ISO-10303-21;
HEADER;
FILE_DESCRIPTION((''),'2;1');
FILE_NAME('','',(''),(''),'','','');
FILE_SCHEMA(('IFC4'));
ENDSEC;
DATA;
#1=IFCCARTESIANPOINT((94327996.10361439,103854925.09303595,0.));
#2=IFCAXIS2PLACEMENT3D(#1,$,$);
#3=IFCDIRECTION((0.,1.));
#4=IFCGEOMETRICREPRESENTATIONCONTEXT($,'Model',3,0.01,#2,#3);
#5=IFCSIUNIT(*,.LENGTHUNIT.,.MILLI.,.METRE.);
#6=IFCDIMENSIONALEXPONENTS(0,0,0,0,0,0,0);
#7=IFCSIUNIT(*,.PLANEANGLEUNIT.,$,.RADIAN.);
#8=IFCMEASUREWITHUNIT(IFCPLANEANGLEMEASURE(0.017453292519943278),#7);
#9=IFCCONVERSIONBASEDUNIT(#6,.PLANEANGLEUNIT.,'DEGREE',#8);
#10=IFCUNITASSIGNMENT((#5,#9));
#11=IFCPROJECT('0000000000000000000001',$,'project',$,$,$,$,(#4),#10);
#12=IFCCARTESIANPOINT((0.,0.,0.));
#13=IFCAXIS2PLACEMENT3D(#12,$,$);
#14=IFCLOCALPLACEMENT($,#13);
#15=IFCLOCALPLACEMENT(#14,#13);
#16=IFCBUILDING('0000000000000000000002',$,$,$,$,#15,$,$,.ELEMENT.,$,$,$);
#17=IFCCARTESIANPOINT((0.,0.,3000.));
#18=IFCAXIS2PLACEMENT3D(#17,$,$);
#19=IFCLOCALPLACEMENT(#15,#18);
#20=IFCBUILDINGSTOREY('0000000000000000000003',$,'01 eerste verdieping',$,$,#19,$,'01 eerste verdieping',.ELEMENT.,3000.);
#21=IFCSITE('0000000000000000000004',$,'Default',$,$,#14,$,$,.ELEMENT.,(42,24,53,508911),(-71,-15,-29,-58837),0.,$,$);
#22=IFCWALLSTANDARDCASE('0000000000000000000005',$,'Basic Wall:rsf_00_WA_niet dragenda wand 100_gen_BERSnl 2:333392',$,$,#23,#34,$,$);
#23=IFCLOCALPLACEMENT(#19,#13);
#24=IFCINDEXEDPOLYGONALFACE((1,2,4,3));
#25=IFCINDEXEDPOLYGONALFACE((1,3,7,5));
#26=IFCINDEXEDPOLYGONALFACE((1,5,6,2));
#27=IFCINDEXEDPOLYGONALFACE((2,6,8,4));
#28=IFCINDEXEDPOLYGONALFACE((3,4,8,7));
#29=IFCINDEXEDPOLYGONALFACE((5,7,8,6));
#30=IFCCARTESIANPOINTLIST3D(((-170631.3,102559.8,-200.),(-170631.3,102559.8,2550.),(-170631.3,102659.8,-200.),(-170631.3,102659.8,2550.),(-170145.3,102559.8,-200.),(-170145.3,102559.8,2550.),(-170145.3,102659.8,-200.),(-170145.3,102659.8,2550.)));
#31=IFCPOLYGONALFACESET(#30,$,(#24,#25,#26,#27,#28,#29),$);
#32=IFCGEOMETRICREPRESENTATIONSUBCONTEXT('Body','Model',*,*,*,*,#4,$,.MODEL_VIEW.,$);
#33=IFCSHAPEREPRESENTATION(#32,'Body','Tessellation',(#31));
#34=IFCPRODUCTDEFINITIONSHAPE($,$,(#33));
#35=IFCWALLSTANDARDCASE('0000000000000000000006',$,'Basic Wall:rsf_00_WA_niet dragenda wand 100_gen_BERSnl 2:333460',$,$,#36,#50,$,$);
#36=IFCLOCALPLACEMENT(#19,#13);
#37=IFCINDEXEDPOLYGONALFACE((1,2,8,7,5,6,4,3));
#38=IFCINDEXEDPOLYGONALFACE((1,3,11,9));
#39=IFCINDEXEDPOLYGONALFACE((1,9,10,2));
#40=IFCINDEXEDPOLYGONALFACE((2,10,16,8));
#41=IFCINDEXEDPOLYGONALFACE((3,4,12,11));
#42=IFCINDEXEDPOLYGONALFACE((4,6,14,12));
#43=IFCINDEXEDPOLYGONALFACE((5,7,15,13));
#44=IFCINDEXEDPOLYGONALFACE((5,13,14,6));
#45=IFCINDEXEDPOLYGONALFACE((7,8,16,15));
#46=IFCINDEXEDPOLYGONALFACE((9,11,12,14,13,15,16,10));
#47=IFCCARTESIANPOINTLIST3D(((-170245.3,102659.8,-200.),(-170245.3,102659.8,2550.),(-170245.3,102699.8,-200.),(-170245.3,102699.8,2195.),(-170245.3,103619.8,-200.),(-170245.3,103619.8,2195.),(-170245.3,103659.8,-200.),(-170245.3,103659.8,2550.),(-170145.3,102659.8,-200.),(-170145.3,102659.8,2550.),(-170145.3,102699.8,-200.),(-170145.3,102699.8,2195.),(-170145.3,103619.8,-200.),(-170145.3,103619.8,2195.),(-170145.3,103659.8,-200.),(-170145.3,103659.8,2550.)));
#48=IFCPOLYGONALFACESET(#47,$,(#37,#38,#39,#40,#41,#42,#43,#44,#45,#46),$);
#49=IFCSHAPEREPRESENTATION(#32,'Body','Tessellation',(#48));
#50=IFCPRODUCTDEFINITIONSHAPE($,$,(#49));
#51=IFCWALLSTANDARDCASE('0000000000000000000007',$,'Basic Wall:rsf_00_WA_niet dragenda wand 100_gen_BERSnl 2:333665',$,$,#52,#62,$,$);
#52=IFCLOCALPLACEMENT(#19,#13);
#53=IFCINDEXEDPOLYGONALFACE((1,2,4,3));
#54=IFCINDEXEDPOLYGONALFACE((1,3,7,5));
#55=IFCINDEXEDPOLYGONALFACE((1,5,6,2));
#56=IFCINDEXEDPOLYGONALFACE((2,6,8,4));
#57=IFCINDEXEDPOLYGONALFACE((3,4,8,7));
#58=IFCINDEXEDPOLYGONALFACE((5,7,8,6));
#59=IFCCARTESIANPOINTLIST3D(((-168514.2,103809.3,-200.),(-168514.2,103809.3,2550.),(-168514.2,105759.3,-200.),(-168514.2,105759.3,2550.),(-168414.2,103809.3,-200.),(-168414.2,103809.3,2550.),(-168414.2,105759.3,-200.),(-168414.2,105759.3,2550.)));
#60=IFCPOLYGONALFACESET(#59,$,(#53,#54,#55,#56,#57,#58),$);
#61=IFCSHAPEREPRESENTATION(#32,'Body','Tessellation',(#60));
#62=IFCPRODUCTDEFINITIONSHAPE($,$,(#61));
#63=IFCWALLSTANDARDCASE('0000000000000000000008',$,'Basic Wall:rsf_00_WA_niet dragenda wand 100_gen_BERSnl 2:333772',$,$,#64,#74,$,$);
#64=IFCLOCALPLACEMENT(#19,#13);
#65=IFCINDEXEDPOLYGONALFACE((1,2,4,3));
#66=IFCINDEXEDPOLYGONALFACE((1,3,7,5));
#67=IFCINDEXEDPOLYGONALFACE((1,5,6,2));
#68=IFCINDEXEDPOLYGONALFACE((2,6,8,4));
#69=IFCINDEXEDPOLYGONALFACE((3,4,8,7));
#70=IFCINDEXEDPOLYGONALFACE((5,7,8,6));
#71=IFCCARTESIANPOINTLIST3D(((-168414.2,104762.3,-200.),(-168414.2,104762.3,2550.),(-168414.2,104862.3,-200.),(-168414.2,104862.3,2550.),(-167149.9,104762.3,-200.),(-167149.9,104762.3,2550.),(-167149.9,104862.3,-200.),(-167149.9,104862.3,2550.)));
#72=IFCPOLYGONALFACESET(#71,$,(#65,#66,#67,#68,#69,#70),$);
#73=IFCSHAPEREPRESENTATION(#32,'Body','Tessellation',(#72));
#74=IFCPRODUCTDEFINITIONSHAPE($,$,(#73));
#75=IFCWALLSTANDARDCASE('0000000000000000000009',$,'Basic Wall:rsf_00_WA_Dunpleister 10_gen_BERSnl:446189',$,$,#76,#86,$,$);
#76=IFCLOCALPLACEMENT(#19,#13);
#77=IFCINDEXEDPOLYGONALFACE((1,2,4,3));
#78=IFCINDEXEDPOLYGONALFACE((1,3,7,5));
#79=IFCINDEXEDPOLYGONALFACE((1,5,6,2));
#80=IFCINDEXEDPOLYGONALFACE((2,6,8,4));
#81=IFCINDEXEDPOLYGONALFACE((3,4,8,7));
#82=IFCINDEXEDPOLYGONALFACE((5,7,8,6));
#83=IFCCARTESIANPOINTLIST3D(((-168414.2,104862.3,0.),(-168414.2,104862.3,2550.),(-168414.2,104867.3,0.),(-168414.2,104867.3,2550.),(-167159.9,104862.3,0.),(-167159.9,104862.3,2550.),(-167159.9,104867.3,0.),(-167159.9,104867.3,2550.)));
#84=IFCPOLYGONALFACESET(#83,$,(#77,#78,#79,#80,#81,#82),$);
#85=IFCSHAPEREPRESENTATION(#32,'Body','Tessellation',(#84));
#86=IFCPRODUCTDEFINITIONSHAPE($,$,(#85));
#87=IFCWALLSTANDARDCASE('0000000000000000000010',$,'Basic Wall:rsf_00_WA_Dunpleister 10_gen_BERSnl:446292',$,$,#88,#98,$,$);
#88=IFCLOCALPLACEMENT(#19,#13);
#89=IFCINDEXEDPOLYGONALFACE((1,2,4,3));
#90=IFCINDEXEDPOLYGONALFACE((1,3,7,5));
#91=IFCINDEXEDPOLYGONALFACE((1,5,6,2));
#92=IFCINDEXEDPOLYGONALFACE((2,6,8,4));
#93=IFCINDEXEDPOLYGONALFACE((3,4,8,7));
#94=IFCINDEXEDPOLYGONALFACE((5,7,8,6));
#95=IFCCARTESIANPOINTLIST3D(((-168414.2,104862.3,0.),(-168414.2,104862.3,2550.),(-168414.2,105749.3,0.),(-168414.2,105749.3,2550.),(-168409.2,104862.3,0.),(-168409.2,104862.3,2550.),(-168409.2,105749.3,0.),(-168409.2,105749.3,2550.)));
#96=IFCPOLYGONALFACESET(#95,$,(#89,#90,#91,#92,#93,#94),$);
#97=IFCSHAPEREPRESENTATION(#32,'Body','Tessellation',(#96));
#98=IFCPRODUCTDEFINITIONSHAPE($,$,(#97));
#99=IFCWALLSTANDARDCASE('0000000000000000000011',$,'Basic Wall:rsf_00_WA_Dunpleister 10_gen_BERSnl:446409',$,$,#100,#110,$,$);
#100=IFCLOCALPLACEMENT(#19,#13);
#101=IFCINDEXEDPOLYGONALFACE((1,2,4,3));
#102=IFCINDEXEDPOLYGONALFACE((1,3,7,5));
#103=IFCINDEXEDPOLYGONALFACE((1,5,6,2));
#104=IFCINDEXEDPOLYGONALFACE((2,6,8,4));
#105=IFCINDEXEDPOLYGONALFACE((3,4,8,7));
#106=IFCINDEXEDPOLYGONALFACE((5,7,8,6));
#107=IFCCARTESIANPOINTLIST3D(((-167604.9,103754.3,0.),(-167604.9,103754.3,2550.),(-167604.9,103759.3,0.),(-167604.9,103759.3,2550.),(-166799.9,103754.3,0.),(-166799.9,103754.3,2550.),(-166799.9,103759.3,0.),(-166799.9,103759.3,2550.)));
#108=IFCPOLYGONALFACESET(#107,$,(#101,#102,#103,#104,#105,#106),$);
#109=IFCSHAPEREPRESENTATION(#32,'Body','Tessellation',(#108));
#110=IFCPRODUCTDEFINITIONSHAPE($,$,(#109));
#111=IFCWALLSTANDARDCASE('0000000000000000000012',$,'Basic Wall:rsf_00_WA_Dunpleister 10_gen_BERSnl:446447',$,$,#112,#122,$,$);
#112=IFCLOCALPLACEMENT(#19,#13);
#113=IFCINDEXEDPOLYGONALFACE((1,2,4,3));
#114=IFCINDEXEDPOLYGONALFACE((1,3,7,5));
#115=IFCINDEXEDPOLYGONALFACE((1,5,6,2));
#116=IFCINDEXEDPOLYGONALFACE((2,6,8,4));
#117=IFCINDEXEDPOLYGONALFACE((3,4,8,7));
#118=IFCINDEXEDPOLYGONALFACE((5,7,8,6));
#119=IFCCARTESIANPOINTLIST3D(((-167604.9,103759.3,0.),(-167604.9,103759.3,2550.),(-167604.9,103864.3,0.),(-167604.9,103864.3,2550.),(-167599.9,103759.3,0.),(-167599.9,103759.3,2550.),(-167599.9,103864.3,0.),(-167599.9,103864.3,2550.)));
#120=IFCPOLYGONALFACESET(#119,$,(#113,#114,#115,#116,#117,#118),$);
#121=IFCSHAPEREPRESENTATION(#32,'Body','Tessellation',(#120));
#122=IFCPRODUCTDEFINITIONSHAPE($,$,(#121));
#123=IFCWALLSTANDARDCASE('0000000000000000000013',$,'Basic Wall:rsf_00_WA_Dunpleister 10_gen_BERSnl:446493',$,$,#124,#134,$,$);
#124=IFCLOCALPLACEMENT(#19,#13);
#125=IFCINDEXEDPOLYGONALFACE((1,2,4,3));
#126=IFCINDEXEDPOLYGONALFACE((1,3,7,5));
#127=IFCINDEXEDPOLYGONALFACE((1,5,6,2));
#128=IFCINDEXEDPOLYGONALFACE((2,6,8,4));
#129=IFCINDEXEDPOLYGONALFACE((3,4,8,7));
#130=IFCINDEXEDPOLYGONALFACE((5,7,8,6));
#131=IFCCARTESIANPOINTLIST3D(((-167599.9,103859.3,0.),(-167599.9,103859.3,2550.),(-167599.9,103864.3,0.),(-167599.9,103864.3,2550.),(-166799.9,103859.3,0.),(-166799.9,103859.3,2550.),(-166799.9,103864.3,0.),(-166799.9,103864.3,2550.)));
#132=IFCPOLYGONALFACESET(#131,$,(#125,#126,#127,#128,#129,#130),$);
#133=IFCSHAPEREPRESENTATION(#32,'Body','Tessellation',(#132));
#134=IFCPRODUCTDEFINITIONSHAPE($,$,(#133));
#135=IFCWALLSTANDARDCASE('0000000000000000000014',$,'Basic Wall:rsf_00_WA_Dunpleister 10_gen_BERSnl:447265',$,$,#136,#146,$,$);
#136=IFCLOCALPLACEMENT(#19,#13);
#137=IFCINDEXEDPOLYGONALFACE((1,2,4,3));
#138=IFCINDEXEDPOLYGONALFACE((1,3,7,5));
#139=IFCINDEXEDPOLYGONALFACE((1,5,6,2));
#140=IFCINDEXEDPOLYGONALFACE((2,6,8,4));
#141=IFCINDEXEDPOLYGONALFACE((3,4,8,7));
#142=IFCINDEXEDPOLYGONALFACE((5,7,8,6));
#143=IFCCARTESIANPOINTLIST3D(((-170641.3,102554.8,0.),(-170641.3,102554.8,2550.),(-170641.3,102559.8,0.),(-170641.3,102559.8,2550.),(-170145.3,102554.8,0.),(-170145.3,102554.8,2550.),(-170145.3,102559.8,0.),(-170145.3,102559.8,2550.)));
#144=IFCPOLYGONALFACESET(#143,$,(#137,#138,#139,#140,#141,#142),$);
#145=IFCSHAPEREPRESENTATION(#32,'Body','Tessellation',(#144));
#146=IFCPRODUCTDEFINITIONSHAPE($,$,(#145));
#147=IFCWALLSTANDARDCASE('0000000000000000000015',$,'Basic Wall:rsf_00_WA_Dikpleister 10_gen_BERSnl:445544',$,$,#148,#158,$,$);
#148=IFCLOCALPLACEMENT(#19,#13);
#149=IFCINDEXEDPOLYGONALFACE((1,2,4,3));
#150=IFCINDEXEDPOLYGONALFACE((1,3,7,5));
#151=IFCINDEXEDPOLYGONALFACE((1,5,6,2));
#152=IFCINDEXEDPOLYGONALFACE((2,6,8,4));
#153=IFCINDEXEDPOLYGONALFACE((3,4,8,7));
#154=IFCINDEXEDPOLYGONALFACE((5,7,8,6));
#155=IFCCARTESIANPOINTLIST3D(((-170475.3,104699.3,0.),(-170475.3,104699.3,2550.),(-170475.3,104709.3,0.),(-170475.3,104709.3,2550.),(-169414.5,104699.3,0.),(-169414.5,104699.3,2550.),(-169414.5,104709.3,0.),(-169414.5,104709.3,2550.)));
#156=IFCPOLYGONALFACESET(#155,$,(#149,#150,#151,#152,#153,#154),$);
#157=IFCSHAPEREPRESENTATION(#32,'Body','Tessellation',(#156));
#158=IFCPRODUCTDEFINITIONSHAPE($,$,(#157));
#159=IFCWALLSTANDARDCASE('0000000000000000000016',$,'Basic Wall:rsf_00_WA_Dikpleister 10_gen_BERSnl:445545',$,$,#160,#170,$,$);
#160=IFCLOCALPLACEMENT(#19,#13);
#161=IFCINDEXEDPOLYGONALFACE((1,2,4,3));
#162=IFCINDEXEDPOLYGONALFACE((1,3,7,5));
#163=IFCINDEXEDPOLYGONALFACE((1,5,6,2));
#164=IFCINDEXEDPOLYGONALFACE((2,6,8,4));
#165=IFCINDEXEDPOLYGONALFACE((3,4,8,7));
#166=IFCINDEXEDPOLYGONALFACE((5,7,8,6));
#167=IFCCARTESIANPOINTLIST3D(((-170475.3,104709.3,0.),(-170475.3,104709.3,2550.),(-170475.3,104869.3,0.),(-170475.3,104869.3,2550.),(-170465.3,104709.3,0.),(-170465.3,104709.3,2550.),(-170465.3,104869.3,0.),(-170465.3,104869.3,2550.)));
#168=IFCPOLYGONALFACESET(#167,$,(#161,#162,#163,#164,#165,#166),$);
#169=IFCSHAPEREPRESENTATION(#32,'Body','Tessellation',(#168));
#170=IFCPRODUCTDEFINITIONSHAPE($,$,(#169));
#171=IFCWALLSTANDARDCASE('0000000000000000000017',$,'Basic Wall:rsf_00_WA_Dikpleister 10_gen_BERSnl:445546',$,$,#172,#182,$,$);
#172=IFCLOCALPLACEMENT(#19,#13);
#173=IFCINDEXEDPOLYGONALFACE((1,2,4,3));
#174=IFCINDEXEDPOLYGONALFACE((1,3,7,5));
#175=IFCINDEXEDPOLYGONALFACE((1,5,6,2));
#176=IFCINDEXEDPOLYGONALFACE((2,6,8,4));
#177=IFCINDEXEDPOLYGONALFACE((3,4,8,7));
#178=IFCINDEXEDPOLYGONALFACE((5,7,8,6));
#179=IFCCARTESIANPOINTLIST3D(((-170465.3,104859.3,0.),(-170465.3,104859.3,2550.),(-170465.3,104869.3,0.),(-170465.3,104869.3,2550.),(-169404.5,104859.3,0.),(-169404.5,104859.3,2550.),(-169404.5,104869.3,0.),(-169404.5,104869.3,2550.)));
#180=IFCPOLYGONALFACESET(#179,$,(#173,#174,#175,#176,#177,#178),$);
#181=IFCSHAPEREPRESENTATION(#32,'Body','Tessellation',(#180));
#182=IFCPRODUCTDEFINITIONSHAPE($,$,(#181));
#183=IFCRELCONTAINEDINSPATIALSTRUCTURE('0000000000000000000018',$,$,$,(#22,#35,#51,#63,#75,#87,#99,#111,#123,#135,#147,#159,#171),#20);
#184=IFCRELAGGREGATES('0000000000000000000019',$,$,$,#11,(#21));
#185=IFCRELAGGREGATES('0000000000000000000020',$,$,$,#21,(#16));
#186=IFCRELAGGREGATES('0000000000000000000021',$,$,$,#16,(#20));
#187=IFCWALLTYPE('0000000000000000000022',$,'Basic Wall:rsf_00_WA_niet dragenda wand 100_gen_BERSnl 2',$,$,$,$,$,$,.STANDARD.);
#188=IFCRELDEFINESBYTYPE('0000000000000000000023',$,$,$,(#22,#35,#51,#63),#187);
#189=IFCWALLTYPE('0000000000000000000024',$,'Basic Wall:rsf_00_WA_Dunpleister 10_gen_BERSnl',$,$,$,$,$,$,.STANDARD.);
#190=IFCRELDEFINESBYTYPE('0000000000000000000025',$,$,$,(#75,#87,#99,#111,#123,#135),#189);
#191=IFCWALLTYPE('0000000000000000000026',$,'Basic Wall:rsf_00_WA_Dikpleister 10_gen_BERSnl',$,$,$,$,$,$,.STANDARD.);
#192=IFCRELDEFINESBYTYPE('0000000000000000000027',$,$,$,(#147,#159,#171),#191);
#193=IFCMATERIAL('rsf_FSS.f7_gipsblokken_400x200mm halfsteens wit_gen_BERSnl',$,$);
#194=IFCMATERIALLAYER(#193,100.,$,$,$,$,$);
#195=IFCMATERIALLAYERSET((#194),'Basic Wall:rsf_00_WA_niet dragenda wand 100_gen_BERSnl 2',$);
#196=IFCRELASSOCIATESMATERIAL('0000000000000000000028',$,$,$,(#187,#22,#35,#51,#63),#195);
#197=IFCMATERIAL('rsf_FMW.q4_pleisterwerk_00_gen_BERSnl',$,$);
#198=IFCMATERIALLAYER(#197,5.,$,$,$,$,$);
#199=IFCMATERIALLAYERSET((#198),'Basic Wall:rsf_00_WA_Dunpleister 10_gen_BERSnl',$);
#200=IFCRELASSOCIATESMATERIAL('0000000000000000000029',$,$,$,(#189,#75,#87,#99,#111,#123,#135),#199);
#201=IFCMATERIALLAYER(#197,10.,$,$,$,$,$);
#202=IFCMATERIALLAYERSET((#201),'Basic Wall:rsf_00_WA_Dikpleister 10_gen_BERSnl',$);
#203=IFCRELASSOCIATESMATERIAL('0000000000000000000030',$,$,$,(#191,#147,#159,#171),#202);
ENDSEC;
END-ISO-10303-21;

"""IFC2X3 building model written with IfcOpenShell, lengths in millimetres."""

from ifc_helpers import new_model, entity, si_unit, converted_unit, direction, frame, frame_2d, origin, place, context, subcontext, project, spatial, rectangle, extrude, material, layer, layer_set, layer_usage, type_object, element, save


model = new_model("IFC2X3")

# Units and contexts
model_context = context("Model", 3, precision=0.01, world=frame((94327996.10361439, 103854925.09303595, 0.0)), true_north=direction((0.0, 1.0)))
body_context = subcontext(model_context, "Body", "Model", "MODEL_VIEW")
ifc_project = project(units=[si_unit("LENGTHUNIT", "METRE", prefix="MILLI"), converted_unit("PLANEANGLEUNIT", "DEGREE", entity("IfcPlaneAngleMeasure", 0.017453292519943278), si_unit("PLANEANGLEUNIT", "RADIAN"), dimensions=[0, 0, 0, 0, 0, 0, 0])], contexts=[model_context])

# Site, building, storey
site_placement = place(None, origin())
site = spatial("IfcSite", under=ifc_project, at=site_placement, Name="Default", CompositionType="ELEMENT", RefLatitude=(42, 24, 53, 508911), RefLongitude=(-71, -15, -29, -58837), RefElevation=0.0)
building_placement = place(site_placement, origin())
building = spatial("IfcBuilding", under=site, at=building_placement, CompositionType="ELEMENT")
storey_placement = place(building_placement, frame((0.0, 0.0, 3000.0)))
storey = spatial("IfcBuildingStorey", under=building, at=storey_placement, Name="01 eerste verdieping", LongName="01 eerste verdieping", CompositionType="ELEMENT", Elevation=3000.0)

# Wall
ifc_material_1 = material(Name="rsf_FSS.f7_gipsblokken_400x200mm halfsteens wit_gen_BERSnl")
ifc_layer_1 = layer(ifc_material_1, 100.0)
ifc_layer_set_1 = layer_set([ifc_layer_1], Name="Basic Wall:rsf_00_WA_niet dragenda wand 100_gen_BERSnl 2")
ifc_layer_usage_1 = layer_usage(ifc_layer_set_1, "AXIS2", "NEGATIVE", 50.0)
wall_type_1 = type_object("IfcWallType", Name="Basic Wall:rsf_00_WA_niet dragenda wand 100_gen_BERSnl 2", PredefinedType="STANDARD", material=ifc_layer_set_1)
wall_1_placement = place(storey_placement, frame((-170631.3, 102609.8, -200.0)))
element("IfcWallStandardCase", 1, at=wall_1_placement, inside=storey, type_object=wall_type_1, material=ifc_layer_usage_1, Name="Basic Wall:rsf_00_WA_niet dragenda wand 100_gen_BERSnl 2:333392", context=body_context, shape_type="SweptSolid", body=[
    extrude(rectangle(XDim=485.9, YDim=100.0, at=frame_2d((243.0, 0.0), x_axis=(-1.0, 0.0))), origin(), (0.0, 0.0, 1.0), 2750.0),
])

# Wall, opening
ifc_layer_usage_2 = layer_usage(ifc_layer_set_1, "AXIS2", "NEGATIVE", 50.0)
wall_2_placement = place(storey_placement, frame((-170195.3, 102659.8, -200.0), z_axis=(0.0, 0.0, 1.0), x_axis=(0.0, 1.0, 0.0)))
wall_2 = element("IfcWallStandardCase", 2, at=wall_2_placement, inside=storey, type_object=wall_type_1, material=ifc_layer_usage_2, Name="Basic Wall:rsf_00_WA_niet dragenda wand 100_gen_BERSnl 2:333460", context=body_context, shape_type="SweptSolid", body=[
    extrude(rectangle(XDim=1000.0, YDim=100.0, at=frame_2d((500.0, 0.0), x_axis=(1.0, 0.0))), origin(), (0.0, 0.0, 1.0), 2750.0),
])
opening_1_placement = place(wall_2_placement, frame((960.0, 50.0, 0.0)))
element("IfcOpeningElement", 3, at=opening_1_placement, cuts=wall_2, ObjectType="Opening", context=body_context, shape_type="SweptSolid", body=[
    extrude(rectangle(XDim=2395.0, YDim=920.0, at=frame_2d((1197.5, 460.0), x_axis=(-1.0, 0.0))), frame((0.0, 0.0, 0.0), z_axis=(0.0, -1.0, 0.0), x_axis=(0.0, 0.0, 1.0)), (0.0, 0.0, 1.0), 100.0),
])

# Walls
ifc_layer_usage_3 = layer_usage(ifc_layer_set_1, "AXIS2", "NEGATIVE", 50.0)
wall_3_placement = place(storey_placement, frame((-168464.2, 103809.3, -200.0), z_axis=(0.0, 0.0, 1.0), x_axis=(0.0, 1.0, 0.0)))
element("IfcWallStandardCase", 4, at=wall_3_placement, inside=storey, type_object=wall_type_1, material=ifc_layer_usage_3, Name="Basic Wall:rsf_00_WA_niet dragenda wand 100_gen_BERSnl 2:333665", context=body_context, shape_type="SweptSolid", body=[
    extrude(rectangle(XDim=1950.0, YDim=100.0, at=frame_2d((975.0, 0.0), x_axis=(-1.0, 0.0))), origin(), (0.0, 0.0, 1.0), 2750.0),
])
ifc_layer_usage_4 = layer_usage(ifc_layer_set_1, "AXIS2", "POSITIVE", -50.0)
wall_4_placement = place(storey_placement, frame((-168414.2, 104812.3, -200.0)))
element("IfcWallStandardCase", 5, at=wall_4_placement, inside=storey, type_object=wall_type_1, material=ifc_layer_usage_4, Name="Basic Wall:rsf_00_WA_niet dragenda wand 100_gen_BERSnl 2:333772", context=body_context, shape_type="SweptSolid", body=[
    extrude(rectangle(XDim=1264.3, YDim=100.0, at=frame_2d((632.1, 0.0), x_axis=(-1.0, 0.0))), origin(), (0.0, 0.0, 1.0), 2750.0),
])
ifc_material_2 = material(Name="rsf_FMW.q4_pleisterwerk_00_gen_BERSnl")
ifc_layer_2 = layer(ifc_material_2, 5.0)
ifc_layer_set_2 = layer_set([ifc_layer_2], Name="Basic Wall:rsf_00_WA_Dunpleister 10_gen_BERSnl")
ifc_layer_usage_5 = layer_usage(ifc_layer_set_2, "AXIS2", "POSITIVE", -2.5)
wall_type_2 = type_object("IfcWallType", Name="Basic Wall:rsf_00_WA_Dunpleister 10_gen_BERSnl", PredefinedType="STANDARD", material=ifc_layer_set_2)
wall_5_placement = place(storey_placement, frame((-167159.9, 104864.8, 0.0), z_axis=(0.0, 0.0, 1.0), x_axis=(-1.0, 0.0, 0.0)))
element("IfcWallStandardCase", 6, at=wall_5_placement, inside=storey, type_object=wall_type_2, material=ifc_layer_usage_5, Name="Basic Wall:rsf_00_WA_Dunpleister 10_gen_BERSnl:446189", context=body_context, shape_type="SweptSolid", body=[
    extrude(rectangle(XDim=1254.3, YDim=5.0, at=frame_2d((627.1, 0.0), x_axis=(-1.0, 0.0))), origin(), (0.0, 0.0, 1.0), 2550.0),
])
ifc_layer_usage_6 = layer_usage(ifc_layer_set_2, "AXIS2", "NEGATIVE", 2.5)
wall_6_placement = place(storey_placement, frame((-168411.7, 105749.3, 0.0), z_axis=(0.0, 0.0, 1.0), x_axis=(0.0, -1.0, 0.0)))
element("IfcWallStandardCase", 7, at=wall_6_placement, inside=storey, type_object=wall_type_2, material=ifc_layer_usage_6, Name="Basic Wall:rsf_00_WA_Dunpleister 10_gen_BERSnl:446292", context=body_context, shape_type="SweptSolid", body=[
    extrude(rectangle(XDim=887.0, YDim=5.0, at=frame_2d((443.5, 0.0), x_axis=(-1.0, 0.0))), origin(), (0.0, 0.0, 1.0), 2550.0),
])
ifc_layer_usage_7 = layer_usage(ifc_layer_set_2, "AXIS2", "NEGATIVE", 2.5)
wall_7_placement = place(storey_placement, frame((-166799.9, 103756.8, 0.0), z_axis=(0.0, 0.0, 1.0), x_axis=(-1.0, 0.0, 0.0)))
element("IfcWallStandardCase", 8, at=wall_7_placement, inside=storey, type_object=wall_type_2, material=ifc_layer_usage_7, Name="Basic Wall:rsf_00_WA_Dunpleister 10_gen_BERSnl:446409", context=body_context, shape_type="SweptSolid", body=[
    extrude(rectangle(XDim=805.0, YDim=5.0, at=frame_2d((402.5, 0.0), x_axis=(-1.0, 0.0))), origin(), (0.0, 0.0, 1.0), 2550.0),
])
ifc_layer_usage_8 = layer_usage(ifc_layer_set_2, "AXIS2", "NEGATIVE", 2.5)
wall_8_placement = place(storey_placement, frame((-167602.4, 103759.3, 0.0), z_axis=(0.0, 0.0, 1.0), x_axis=(0.0, 1.0, 0.0)))
element("IfcWallStandardCase", 9, at=wall_8_placement, inside=storey, type_object=wall_type_2, material=ifc_layer_usage_8, Name="Basic Wall:rsf_00_WA_Dunpleister 10_gen_BERSnl:446447", context=body_context, shape_type="SweptSolid", body=[
    extrude(rectangle(XDim=105.0, YDim=5.0, at=frame_2d((52.5, 0.0), x_axis=(-1.0, 0.0))), origin(), (0.0, 0.0, 1.0), 2550.0),
])
ifc_layer_usage_9 = layer_usage(ifc_layer_set_2, "AXIS2", "NEGATIVE", 2.5)
wall_9_placement = place(storey_placement, frame((-167599.9, 103861.8, 0.0)))
element("IfcWallStandardCase", 10, at=wall_9_placement, inside=storey, type_object=wall_type_2, material=ifc_layer_usage_9, Name="Basic Wall:rsf_00_WA_Dunpleister 10_gen_BERSnl:446493", context=body_context, shape_type="SweptSolid", body=[
    extrude(rectangle(XDim=800.0, YDim=5.0, at=frame_2d((400.0, 0.0), x_axis=(-1.0, 0.0))), origin(), (0.0, 0.0, 1.0), 2550.0),
])

# Walls
ifc_layer_usage_10 = layer_usage(ifc_layer_set_2, "AXIS2", "NEGATIVE", 2.5)
wall_10_placement = place(storey_placement, frame((-170145.3, 102557.3, 0.0), z_axis=(0.0, 0.0, 1.0), x_axis=(-1.0, 0.0, 0.0)))
element("IfcWallStandardCase", 11, at=wall_10_placement, inside=storey, type_object=wall_type_2, material=ifc_layer_usage_10, Name="Basic Wall:rsf_00_WA_Dunpleister 10_gen_BERSnl:447265", context=body_context, shape_type="SweptSolid", body=[
    extrude(rectangle(XDim=495.9, YDim=5.0, at=frame_2d((248.0, 0.0), x_axis=(-1.0, 0.0))), origin(), (0.0, 0.0, 1.0), 2550.0),
])
ifc_layer_3 = layer(ifc_material_2, 10.0)
ifc_layer_set_3 = layer_set([ifc_layer_3], Name="Basic Wall:rsf_00_WA_Dikpleister 10_gen_BERSnl")
ifc_layer_usage_11 = layer_usage(ifc_layer_set_3, "AXIS2", "NEGATIVE", 5.0)
wall_type_3 = type_object("IfcWallType", Name="Basic Wall:rsf_00_WA_Dikpleister 10_gen_BERSnl", PredefinedType="STANDARD", material=ifc_layer_set_3)
wall_11_placement = place(storey_placement, frame((-170475.3, 104704.3, 0.0)))
element("IfcWallStandardCase", 12, at=wall_11_placement, inside=storey, type_object=wall_type_3, material=ifc_layer_usage_11, Name="Basic Wall:rsf_00_WA_Dikpleister 10_gen_BERSnl:445544", context=body_context, shape_type="SweptSolid", body=[
    extrude(rectangle(XDim=1060.8, YDim=10.0, at=frame_2d((530.4, 0.0), x_axis=(-1.0, 0.0))), origin(), (0.0, 0.0, 1.0), 2550.0),
])
ifc_layer_usage_12 = layer_usage(ifc_layer_set_3, "AXIS2", "NEGATIVE", 5.0)
wall_12_placement = place(storey_placement, frame((-170470.3, 104869.3, 0.0), z_axis=(0.0, 0.0, 1.0), x_axis=(0.0, -1.0, 0.0)))
element("IfcWallStandardCase", 13, at=wall_12_placement, inside=storey, type_object=wall_type_3, material=ifc_layer_usage_12, Name="Basic Wall:rsf_00_WA_Dikpleister 10_gen_BERSnl:445545", context=body_context, shape_type="SweptSolid", body=[
    extrude(rectangle(XDim=160.0, YDim=10.0, at=frame_2d((80.0, 0.0), x_axis=(-1.0, 0.0))), origin(), (0.0, 0.0, 1.0), 2550.0),
])
ifc_layer_usage_13 = layer_usage(ifc_layer_set_3, "AXIS2", "NEGATIVE", 5.0)
wall_13_placement = place(storey_placement, frame((-169404.5, 104864.3, 0.0), z_axis=(0.0, 0.0, 1.0), x_axis=(-1.0, 0.0, 0.0)))
element("IfcWallStandardCase", 14, at=wall_13_placement, inside=storey, type_object=wall_type_3, material=ifc_layer_usage_13, Name="Basic Wall:rsf_00_WA_Dikpleister 10_gen_BERSnl:445546", context=body_context, shape_type="SweptSolid", body=[
    extrude(rectangle(XDim=1060.8, YDim=10.0, at=frame_2d((530.4, 0.0), x_axis=(-1.0, 0.0))), origin(), (0.0, 0.0, 1.0), 2550.0),
])

save(model, "model.ifc")
